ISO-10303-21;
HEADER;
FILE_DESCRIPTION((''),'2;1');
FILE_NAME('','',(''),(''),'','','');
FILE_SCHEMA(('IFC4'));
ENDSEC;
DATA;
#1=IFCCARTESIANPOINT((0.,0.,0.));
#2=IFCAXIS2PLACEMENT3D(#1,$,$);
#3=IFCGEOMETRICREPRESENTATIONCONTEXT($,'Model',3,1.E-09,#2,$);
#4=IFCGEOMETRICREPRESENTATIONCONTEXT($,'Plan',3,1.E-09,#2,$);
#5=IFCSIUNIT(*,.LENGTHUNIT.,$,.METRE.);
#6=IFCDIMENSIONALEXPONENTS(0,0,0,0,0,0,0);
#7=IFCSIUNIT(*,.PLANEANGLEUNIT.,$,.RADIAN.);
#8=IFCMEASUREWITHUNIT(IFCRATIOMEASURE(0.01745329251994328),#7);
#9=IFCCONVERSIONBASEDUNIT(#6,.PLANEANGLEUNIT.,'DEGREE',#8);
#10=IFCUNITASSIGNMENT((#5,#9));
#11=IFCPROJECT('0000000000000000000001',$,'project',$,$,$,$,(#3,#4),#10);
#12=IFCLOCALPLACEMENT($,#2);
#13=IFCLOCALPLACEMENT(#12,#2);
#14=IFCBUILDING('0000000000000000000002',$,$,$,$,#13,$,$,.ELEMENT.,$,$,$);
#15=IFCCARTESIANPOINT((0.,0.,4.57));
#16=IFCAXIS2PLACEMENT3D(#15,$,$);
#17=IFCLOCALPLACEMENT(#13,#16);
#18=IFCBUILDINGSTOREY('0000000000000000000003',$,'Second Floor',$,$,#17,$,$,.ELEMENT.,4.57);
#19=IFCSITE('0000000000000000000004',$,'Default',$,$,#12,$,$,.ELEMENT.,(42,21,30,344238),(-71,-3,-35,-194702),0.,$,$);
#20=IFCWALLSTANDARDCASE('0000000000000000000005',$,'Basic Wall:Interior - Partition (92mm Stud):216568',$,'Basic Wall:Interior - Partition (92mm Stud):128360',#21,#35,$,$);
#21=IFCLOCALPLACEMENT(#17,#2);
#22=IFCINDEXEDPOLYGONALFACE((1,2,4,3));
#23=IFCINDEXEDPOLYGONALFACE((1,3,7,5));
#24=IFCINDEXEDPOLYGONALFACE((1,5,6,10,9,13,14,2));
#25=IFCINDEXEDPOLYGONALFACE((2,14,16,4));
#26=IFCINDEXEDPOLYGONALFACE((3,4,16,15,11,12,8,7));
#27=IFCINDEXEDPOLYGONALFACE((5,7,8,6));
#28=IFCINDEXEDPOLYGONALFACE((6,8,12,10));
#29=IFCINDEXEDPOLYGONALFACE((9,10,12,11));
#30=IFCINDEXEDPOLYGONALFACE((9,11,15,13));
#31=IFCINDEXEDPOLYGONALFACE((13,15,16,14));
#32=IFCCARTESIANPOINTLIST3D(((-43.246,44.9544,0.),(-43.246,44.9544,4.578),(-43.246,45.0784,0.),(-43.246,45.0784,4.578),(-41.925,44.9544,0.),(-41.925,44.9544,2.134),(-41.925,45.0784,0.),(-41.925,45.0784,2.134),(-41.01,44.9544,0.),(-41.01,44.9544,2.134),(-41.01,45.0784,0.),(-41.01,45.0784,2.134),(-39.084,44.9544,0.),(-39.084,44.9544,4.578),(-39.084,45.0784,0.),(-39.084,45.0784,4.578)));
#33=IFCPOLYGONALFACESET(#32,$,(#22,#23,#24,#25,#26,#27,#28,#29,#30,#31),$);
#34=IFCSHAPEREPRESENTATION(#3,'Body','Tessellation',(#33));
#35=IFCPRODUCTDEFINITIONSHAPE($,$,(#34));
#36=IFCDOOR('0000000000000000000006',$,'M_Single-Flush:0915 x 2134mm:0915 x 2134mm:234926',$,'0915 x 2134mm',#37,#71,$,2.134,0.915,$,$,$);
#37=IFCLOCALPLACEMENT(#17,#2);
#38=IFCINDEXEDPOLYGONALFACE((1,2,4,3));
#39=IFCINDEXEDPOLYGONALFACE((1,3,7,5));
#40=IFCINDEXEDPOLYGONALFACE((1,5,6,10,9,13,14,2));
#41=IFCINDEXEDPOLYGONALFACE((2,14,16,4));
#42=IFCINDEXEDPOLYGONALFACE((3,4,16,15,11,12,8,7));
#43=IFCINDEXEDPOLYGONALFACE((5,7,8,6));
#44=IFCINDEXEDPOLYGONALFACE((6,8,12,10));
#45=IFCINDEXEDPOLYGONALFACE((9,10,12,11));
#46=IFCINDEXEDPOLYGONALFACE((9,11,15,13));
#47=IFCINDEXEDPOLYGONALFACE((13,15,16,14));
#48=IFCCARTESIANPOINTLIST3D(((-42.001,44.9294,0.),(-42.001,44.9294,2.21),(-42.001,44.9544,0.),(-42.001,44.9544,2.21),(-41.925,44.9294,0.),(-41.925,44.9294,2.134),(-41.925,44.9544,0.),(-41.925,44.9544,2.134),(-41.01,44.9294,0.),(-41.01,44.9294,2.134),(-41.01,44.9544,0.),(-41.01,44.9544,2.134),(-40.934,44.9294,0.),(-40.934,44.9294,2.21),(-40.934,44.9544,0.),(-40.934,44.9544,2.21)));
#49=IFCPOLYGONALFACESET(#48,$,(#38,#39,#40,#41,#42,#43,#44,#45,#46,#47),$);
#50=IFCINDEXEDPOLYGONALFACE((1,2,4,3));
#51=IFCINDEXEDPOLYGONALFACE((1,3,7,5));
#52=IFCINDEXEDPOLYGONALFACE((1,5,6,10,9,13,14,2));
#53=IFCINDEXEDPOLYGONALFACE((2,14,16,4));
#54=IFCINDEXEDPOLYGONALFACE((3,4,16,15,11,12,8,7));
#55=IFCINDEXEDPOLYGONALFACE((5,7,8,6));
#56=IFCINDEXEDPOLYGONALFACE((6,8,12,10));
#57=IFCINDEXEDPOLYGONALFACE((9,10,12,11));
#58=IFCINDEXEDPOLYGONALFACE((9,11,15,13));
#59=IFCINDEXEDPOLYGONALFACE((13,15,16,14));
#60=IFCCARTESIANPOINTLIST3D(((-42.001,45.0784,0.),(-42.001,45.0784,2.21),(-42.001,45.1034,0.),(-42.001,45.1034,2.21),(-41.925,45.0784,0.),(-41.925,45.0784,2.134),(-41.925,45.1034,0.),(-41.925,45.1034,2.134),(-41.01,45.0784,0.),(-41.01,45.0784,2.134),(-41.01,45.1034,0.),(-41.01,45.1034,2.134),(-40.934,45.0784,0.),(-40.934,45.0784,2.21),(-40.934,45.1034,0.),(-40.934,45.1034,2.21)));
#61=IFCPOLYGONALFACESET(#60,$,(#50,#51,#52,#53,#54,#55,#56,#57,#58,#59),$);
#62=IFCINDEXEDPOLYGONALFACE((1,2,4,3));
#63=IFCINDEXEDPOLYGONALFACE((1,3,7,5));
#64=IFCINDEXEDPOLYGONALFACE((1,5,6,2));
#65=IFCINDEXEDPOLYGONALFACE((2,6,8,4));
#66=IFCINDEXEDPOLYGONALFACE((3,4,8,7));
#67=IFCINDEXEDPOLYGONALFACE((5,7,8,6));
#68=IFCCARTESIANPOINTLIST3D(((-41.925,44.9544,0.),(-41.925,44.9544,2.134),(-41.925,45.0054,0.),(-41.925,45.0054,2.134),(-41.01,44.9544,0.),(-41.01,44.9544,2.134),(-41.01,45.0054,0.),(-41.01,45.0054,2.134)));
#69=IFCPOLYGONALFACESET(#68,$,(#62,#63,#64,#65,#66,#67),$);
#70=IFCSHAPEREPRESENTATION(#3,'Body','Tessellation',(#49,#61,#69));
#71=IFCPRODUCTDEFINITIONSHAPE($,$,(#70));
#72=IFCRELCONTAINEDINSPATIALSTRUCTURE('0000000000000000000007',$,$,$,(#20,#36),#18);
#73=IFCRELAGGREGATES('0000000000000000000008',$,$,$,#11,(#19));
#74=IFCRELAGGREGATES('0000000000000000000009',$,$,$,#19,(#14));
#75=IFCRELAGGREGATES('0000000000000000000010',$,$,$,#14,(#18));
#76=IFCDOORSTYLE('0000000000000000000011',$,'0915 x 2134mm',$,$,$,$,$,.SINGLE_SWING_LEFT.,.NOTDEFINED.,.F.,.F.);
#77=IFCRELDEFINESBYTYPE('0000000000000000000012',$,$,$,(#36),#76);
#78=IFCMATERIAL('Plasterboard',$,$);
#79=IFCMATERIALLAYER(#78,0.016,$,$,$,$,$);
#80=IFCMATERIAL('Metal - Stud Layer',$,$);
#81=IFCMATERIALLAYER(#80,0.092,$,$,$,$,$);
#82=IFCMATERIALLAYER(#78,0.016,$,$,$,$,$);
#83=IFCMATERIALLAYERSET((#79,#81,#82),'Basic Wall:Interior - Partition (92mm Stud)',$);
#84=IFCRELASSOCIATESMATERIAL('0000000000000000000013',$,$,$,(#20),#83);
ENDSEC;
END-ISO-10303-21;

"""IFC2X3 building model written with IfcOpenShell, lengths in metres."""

from ifc_helpers import new_model, entity, si_unit, converted_unit, frame, frame_2d, origin, origin_2d_with_axis, place, context, project, spatial, polyline, rectangle, outline, extrude, source, transform, mapped, material, layer, layer_set, layer_usage, type_object, type_shapes, element, fill, save


model = new_model("IFC2X3")

# Units and contexts
model_context = context("Model", 3, precision=1e-09, world=origin())
plan_context = context("Plan", 3, precision=1e-09, world=origin())
ifc_project = project(units=[si_unit("LENGTHUNIT", "METRE"), converted_unit("PLANEANGLEUNIT", "DEGREE", entity("IfcRatioMeasure", 0.01745329251994328), si_unit("PLANEANGLEUNIT", "RADIAN"), dimensions=[0, 0, 0, 0, 0, 0, 0])], contexts=[model_context, plan_context])

# Site, building, storey
site_placement = place(None, origin())
site = spatial("IfcSite", under=ifc_project, at=site_placement, Name="Default", CompositionType="ELEMENT", RefLatitude=(42, 21, 30, 344238), RefLongitude=(-71, -3, -35, -194702), RefElevation=0.0)
building_placement = place(site_placement, origin())
building = spatial("IfcBuilding", under=site, at=building_placement, CompositionType="ELEMENT")
storey_placement = place(building_placement, frame((0.0, 0.0, 4.57)))
storey = spatial("IfcBuildingStorey", under=building, at=storey_placement, Name="Second Floor", CompositionType="ELEMENT", Elevation=4.57)

# Wall, opening, door
ifc_material_1 = material(Name="Plasterboard")
ifc_layer_1 = layer(ifc_material_1, 0.016)
ifc_material_2 = material(Name="Metal - Stud Layer")
ifc_layer_2 = layer(ifc_material_2, 0.092)
ifc_layer_3 = layer(ifc_material_1, 0.016)
ifc_layer_set_1 = layer_set([ifc_layer_1, ifc_layer_2, ifc_layer_3], Name="Basic Wall:Interior - Partition (92mm Stud)")
ifc_layer_usage_1 = layer_usage(ifc_layer_set_1, "AXIS2", "NEGATIVE", 0.062)
wall_1_placement = place(storey_placement, frame((-43.246, 45.0164, 0.0)))
wall_1 = element("IfcWallStandardCase", 1, at=wall_1_placement, inside=storey, material=ifc_layer_usage_1, Name="Basic Wall:Interior - Partition (92mm Stud):216568", ObjectType="Basic Wall:Interior - Partition (92mm Stud):128360", context=model_context, shape_type="SweptSolid", body=[
    extrude(rectangle(XDim=4.162, YDim=0.124, at=frame_2d((2.081, 0.0), x_axis=(-1.0, 0.0))), origin(), (0.0, 0.0, 1.0), 4.578),
])
opening_1_placement = place(wall_1_placement, frame((2.236, 0.062, 0.0)))
opening_1 = element("IfcOpeningElement", 2, at=opening_1_placement, cuts=wall_1, ObjectType="Opening", context=model_context, shape_type="SweptSolid", body=[
    extrude(rectangle(XDim=0.915, YDim=2.134, at=frame_2d((1.067, 0.4575), x_axis=(0.0, -1.0))), frame((0.0, 0.0, 0.0), z_axis=(0.0, -1.0, 0.0), x_axis=(0.0, 0.0, 1.0)), (0.0, 0.0, 1.0), 0.124),
])
door_style_1 = type_object("IfcDoorStyle", Name="0915 x 2134mm", ConstructionType="NOTDEFINED", OperationType="SINGLE_SWING_LEFT", ParameterTakesPrecedence=False, Sizeable=False)
shared_shape_1 = source(origin(), model_context, "Body", "SweptSolid", [
    extrude(outline(polyline([(-0.5335, -1.124), (0.5335, -1.124), (0.5335, 1.086), (0.4575, 1.086), (0.4575, -1.048), (-0.4575, -1.048), (-0.4575, 1.086), (-0.5335, 1.086), (-0.5335, -1.124)])), frame((0.4575, 0.149, 1.086), z_axis=(0.0, -1.0, 0.0), x_axis=(-1.0, 0.0, 0.0)), (0.0, 0.0, 1.0), 0.025),
    extrude(outline(polyline([(-1.124, -0.5335), (1.086, -0.5335), (1.086, -0.4575), (-1.048, -0.4575), (-1.048, 0.4575), (1.086, 0.4575), (1.086, 0.5335), (-1.124, 0.5335), (-1.124, -0.5335)])), frame((0.4575, 0.0, 1.086), z_axis=(0.0, -1.0, 0.0), x_axis=(0.0, 0.0, -1.0)), (0.0, 0.0, 1.0), 0.025),
    extrude(rectangle(XDim=0.915, YDim=0.051, at=origin_2d_with_axis()), frame((0.4575, 0.0985, 0.0)), (0.0, 0.0, 1.0), 2.134),
])
type_shapes(door_style_1, [shared_shape_1])
door_1_placement = place(opening_1_placement, frame((0.0, 0.0, 0.0), z_axis=(0.0, 0.0, 1.0), x_axis=(-1.0, 0.0, 0.0)))
door_1 = element("IfcDoor", 3, at=door_1_placement, inside=storey, type_object=door_style_1, Name="M_Single-Flush:0915 x 2134mm:0915 x 2134mm:234926", ObjectType="0915 x 2134mm", OverallHeight=2.134, OverallWidth=0.915, context=model_context, shape_type="MappedRepresentation", body=[
    mapped(shared_shape_1, transform((0.0, 0.0, 0.0), scale=1.0)),
])
fill(opening_1, door_1)

save(model, "model.ifc")
